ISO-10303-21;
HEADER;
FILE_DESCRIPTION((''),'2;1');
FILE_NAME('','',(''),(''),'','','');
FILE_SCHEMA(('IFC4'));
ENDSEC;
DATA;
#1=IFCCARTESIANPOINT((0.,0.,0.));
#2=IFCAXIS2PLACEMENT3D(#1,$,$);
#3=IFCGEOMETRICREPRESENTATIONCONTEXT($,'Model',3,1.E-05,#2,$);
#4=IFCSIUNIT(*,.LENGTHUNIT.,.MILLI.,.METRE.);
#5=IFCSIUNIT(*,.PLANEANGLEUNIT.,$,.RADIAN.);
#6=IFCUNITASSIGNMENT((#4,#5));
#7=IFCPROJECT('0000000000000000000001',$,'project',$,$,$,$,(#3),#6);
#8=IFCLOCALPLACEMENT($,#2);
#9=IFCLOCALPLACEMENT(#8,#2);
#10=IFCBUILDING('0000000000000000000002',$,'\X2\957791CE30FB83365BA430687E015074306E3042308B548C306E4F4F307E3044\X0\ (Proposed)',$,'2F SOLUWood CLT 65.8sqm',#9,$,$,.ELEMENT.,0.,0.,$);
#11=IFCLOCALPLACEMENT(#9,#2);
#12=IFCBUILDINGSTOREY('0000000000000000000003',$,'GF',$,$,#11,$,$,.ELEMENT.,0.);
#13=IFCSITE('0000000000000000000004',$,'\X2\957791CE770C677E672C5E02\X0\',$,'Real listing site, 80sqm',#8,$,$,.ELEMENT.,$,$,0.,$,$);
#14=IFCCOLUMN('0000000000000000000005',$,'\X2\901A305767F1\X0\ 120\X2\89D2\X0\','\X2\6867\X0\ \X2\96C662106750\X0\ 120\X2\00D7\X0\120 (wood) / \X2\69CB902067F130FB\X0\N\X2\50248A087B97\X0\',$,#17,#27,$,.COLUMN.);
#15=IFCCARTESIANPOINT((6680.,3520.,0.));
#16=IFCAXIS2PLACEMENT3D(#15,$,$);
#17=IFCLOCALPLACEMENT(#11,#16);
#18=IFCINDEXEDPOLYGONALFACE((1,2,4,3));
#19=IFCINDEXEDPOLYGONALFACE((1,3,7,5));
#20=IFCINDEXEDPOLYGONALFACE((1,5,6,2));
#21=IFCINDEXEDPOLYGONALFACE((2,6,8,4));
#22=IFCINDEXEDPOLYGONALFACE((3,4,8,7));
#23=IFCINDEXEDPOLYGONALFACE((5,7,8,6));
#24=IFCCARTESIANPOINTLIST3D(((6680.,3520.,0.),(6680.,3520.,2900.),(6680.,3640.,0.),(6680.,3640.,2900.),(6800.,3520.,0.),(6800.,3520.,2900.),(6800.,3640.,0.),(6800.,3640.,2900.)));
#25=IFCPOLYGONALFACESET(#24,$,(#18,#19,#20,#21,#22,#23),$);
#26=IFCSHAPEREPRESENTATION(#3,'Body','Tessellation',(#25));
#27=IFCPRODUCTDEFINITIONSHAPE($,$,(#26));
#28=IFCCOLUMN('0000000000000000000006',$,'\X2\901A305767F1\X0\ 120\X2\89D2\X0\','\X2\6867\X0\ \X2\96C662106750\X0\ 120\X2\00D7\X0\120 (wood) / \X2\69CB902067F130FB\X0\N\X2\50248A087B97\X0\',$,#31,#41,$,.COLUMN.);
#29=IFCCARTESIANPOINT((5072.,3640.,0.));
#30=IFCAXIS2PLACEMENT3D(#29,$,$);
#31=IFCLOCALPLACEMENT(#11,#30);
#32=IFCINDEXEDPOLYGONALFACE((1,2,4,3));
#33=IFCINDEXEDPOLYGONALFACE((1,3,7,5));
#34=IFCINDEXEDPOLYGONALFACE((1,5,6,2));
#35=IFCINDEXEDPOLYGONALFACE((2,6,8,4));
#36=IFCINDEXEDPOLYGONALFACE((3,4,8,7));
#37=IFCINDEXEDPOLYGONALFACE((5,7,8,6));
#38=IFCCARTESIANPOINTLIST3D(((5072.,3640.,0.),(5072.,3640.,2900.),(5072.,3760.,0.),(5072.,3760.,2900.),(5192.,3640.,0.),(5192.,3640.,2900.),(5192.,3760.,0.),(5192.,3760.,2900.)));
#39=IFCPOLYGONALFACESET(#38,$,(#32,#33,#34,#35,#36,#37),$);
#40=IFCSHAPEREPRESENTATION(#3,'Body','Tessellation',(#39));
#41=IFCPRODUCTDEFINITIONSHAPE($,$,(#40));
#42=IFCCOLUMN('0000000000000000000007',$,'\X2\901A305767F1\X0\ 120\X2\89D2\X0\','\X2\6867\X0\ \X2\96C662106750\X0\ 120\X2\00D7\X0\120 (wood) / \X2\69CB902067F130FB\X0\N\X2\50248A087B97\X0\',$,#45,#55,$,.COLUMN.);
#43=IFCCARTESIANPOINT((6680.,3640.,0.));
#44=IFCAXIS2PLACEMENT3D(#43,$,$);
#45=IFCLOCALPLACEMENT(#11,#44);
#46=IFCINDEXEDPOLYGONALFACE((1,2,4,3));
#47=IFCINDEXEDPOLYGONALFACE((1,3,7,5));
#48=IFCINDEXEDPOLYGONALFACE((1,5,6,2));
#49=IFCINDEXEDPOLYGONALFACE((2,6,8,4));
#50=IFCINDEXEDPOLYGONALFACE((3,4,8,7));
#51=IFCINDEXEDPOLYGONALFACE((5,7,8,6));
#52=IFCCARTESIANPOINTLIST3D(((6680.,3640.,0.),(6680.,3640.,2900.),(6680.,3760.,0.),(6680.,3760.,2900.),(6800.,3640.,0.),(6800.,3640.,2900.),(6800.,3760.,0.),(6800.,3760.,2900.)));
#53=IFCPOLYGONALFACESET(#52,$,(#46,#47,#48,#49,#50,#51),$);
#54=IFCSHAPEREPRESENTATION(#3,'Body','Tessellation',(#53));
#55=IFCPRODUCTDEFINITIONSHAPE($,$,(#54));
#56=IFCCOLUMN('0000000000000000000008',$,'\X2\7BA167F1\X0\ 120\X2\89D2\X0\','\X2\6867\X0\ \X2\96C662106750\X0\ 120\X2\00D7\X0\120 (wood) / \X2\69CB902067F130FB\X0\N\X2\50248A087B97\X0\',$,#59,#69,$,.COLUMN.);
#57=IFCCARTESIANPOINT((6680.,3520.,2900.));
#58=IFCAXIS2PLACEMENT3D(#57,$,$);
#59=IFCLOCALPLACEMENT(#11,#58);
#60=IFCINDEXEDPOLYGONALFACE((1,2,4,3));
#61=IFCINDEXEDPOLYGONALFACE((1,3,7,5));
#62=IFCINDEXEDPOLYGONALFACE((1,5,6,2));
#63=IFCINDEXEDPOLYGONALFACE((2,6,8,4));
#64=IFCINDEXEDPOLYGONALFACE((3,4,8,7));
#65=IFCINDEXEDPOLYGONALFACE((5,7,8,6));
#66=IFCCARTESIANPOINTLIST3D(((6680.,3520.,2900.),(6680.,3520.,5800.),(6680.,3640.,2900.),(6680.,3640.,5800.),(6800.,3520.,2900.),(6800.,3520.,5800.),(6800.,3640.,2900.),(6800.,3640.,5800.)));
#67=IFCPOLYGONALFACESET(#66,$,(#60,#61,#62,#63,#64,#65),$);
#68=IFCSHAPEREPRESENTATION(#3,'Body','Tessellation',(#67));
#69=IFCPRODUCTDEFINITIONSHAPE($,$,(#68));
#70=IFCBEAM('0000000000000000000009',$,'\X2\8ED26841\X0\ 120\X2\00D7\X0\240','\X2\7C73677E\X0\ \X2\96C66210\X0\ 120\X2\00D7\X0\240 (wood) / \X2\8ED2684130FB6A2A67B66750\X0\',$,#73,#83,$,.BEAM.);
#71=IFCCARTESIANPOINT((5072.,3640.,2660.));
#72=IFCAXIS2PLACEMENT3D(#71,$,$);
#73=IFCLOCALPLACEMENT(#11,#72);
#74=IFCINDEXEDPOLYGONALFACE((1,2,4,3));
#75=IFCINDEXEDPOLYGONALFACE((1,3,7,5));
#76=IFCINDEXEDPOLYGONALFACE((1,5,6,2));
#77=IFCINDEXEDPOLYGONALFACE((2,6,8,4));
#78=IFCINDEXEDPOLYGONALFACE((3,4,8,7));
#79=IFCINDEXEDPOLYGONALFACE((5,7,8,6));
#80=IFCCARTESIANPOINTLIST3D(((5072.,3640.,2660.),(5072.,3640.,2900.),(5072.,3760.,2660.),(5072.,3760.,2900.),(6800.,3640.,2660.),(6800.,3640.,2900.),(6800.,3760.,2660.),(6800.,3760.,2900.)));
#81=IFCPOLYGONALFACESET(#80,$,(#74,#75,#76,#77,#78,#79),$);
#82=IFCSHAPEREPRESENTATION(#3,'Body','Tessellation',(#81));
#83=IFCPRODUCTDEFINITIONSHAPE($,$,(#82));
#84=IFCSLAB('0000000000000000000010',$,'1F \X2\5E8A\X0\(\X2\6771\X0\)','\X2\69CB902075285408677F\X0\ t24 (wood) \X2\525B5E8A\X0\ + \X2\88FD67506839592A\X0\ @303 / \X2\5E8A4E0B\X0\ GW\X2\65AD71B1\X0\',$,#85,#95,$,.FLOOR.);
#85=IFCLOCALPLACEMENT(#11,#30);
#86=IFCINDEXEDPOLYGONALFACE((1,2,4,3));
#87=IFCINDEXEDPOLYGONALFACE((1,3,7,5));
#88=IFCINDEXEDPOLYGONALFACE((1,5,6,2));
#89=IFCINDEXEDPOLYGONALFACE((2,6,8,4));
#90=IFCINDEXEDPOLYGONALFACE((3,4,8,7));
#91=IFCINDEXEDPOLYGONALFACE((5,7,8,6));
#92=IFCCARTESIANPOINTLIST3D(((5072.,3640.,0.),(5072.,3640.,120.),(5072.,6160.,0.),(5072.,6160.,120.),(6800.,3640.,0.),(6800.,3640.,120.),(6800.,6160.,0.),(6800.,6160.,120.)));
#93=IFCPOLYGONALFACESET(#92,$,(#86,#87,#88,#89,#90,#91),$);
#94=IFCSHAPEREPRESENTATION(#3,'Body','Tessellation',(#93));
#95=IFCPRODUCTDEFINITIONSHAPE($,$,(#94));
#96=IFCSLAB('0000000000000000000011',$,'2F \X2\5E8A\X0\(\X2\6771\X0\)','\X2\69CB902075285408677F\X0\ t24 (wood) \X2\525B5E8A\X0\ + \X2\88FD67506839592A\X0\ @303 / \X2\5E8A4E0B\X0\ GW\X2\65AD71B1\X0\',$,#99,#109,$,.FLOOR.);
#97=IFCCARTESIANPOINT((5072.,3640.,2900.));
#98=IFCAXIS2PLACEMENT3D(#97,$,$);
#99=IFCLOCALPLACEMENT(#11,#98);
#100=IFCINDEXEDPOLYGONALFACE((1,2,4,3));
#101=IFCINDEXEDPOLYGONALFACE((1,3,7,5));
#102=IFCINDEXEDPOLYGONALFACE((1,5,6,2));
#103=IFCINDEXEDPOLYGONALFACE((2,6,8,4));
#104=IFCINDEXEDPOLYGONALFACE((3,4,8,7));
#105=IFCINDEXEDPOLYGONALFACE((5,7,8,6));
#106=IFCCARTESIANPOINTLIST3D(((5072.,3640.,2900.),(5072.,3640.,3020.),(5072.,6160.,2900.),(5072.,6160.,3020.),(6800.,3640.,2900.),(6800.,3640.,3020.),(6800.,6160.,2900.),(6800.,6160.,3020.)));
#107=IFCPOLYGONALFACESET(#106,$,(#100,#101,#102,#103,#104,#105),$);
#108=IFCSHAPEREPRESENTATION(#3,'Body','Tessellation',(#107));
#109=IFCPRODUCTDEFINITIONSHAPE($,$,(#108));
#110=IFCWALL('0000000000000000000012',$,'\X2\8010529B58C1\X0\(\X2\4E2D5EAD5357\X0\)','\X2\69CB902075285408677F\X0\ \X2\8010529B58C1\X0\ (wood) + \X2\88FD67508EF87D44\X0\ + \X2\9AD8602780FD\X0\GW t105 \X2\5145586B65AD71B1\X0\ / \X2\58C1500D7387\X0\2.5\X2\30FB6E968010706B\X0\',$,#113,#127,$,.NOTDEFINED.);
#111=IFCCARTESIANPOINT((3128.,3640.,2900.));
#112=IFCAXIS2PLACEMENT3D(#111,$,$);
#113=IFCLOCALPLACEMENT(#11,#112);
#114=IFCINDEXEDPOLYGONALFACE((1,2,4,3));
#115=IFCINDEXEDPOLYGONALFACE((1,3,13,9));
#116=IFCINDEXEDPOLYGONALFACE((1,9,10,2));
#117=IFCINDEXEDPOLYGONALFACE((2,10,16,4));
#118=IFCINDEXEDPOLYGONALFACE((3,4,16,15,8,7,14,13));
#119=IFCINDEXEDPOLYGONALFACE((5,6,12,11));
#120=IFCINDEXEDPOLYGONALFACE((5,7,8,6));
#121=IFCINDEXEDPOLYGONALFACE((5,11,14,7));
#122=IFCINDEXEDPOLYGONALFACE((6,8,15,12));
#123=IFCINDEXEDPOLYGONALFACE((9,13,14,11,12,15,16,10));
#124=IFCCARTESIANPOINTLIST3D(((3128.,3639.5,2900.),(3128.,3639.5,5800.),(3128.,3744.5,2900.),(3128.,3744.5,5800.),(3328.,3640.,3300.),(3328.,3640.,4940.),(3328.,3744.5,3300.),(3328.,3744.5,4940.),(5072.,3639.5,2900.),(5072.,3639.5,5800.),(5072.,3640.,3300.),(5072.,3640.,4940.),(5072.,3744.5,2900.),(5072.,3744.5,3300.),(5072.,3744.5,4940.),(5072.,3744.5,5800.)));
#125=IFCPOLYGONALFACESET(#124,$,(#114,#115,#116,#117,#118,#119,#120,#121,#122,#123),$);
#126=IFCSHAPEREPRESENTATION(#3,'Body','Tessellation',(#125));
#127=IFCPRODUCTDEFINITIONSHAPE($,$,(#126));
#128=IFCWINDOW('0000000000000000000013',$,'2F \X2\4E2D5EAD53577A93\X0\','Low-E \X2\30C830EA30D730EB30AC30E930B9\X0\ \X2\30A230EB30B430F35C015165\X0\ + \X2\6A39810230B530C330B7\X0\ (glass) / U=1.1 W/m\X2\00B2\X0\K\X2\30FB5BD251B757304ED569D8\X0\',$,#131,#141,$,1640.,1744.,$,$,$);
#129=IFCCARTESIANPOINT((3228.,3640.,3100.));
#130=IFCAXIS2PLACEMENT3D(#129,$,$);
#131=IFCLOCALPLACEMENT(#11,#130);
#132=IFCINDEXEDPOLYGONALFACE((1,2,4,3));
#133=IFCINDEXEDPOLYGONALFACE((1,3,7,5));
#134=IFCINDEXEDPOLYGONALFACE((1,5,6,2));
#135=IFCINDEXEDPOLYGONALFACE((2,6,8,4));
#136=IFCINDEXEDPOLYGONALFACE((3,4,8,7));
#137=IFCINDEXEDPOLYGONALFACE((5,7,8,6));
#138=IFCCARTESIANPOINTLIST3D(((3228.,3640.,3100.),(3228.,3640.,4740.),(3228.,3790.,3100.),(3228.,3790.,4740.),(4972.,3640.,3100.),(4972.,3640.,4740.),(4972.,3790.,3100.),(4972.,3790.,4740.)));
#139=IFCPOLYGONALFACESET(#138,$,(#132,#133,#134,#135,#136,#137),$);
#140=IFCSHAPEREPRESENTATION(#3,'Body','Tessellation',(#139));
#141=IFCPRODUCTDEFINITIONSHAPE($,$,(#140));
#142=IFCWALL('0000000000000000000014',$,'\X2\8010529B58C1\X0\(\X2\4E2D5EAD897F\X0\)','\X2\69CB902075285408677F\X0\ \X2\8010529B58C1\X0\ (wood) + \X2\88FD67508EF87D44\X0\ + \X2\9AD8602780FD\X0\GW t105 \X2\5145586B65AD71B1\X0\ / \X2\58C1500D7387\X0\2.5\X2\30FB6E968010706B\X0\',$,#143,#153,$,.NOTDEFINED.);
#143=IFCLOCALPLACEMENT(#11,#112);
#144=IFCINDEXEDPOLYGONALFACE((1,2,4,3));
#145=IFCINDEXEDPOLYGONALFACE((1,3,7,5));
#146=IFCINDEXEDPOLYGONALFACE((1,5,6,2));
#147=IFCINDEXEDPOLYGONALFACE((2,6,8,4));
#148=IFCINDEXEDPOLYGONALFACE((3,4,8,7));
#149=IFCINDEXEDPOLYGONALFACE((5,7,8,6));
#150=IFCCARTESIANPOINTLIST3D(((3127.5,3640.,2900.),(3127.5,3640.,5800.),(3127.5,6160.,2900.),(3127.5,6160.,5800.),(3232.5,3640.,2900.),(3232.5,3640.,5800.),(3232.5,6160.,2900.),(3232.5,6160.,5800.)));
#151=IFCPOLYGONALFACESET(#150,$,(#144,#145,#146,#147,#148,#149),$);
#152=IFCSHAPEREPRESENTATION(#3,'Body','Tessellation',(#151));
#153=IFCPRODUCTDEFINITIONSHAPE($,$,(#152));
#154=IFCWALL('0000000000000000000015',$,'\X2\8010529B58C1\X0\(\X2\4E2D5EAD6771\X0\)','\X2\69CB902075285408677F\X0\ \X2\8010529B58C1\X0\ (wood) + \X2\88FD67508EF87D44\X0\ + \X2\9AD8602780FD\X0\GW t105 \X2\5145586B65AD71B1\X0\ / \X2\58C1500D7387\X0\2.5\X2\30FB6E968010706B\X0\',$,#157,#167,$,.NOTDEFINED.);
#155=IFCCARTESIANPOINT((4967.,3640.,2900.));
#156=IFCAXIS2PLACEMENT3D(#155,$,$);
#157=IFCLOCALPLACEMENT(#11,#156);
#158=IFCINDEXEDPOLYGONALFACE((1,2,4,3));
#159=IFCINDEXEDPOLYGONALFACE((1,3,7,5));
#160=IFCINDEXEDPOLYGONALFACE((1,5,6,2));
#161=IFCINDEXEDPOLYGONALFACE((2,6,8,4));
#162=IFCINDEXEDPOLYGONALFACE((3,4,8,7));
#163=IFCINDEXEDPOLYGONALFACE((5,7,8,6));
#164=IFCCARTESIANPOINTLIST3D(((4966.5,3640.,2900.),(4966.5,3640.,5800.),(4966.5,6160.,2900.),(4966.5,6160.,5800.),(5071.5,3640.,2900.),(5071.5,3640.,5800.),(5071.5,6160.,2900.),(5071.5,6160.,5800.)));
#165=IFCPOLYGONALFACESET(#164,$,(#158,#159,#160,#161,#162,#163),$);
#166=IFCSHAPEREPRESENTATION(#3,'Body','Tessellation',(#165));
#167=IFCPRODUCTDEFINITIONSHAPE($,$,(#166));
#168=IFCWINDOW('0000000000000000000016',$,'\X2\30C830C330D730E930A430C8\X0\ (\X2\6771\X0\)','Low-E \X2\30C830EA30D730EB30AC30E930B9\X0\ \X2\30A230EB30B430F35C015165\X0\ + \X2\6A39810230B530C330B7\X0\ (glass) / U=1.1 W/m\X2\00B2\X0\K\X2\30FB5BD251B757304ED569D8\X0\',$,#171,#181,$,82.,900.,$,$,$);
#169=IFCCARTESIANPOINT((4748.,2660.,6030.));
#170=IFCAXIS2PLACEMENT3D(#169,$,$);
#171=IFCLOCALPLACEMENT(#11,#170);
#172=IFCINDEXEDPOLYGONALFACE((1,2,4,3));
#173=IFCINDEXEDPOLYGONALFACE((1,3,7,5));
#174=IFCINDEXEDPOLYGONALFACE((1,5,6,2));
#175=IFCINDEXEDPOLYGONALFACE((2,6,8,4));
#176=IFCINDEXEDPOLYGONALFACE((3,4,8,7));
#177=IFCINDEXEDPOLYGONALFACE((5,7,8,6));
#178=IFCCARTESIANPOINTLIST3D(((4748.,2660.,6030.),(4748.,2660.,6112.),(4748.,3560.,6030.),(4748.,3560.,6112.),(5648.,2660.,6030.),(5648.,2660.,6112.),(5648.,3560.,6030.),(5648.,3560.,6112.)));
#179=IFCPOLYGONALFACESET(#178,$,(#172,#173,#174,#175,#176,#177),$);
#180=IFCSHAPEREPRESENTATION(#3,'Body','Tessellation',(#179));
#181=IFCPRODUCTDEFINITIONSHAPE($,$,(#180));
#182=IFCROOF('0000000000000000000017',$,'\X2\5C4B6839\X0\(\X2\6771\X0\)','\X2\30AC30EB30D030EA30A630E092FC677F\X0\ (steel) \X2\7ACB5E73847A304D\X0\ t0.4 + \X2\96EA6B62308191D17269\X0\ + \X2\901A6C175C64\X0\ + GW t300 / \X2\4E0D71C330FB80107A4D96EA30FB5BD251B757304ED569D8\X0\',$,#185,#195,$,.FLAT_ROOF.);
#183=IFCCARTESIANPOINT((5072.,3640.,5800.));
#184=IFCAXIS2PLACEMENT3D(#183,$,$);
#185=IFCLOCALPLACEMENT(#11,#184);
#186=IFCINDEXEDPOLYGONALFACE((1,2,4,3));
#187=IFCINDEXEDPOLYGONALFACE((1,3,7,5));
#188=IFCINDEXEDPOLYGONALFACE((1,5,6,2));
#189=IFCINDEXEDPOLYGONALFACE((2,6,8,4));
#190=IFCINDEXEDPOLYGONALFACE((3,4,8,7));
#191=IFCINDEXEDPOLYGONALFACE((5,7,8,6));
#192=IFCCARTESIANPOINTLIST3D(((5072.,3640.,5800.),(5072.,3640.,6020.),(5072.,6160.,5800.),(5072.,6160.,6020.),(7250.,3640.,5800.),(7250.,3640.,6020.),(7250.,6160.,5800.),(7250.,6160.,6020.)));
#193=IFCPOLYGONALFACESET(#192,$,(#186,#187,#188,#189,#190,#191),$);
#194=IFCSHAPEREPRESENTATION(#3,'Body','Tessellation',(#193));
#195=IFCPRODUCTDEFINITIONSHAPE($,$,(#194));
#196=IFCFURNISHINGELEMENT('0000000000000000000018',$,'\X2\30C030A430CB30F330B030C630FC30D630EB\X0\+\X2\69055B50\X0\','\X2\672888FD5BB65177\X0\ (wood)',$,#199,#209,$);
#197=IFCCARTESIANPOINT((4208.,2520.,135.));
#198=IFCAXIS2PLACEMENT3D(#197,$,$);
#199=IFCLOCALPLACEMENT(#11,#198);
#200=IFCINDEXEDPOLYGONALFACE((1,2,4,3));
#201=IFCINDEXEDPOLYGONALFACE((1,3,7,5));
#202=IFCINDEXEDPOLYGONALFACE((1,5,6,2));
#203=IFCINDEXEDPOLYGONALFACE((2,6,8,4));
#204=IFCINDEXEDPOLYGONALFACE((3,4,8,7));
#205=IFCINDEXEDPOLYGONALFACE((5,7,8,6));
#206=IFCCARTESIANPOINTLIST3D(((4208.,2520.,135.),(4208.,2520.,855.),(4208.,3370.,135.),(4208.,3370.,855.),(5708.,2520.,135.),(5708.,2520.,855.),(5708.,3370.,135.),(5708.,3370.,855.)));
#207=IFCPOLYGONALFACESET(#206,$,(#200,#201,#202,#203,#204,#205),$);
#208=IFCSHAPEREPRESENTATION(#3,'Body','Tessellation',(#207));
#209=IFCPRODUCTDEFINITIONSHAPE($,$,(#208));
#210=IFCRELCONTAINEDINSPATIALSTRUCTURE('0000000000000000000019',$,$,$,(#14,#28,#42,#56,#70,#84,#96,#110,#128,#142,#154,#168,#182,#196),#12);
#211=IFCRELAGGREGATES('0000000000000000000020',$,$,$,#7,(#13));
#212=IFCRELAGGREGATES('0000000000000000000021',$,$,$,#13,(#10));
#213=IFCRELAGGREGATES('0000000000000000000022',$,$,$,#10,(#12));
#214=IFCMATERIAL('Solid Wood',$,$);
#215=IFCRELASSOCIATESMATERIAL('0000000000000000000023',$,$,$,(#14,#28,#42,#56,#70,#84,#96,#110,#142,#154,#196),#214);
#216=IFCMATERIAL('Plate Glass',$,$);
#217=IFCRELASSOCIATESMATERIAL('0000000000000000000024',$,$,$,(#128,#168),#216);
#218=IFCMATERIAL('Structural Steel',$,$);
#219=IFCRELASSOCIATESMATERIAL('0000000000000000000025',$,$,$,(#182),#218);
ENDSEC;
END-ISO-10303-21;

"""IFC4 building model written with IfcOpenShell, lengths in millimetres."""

from ifc_helpers import new_model, si_unit, frame, frame_2d, origin, place, context, project, spatial, rectangle, extrude, material, element, fill, save


model = new_model("IFC4")

# Units and contexts
model_context = context("Model", 3, precision=1e-05, world=origin())
ifc_project = project(units=[si_unit("LENGTHUNIT", "METRE", prefix="MILLI"), si_unit("PLANEANGLEUNIT", "RADIAN")], contexts=[model_context])

# Site, building, storey
site_placement = place(None, origin())
site = spatial("IfcSite", under=ifc_project, at=site_placement, Name="長野県松本市", ObjectType="Real listing site, 80sqm", CompositionType="ELEMENT", RefElevation=0.0)
building_placement = place(site_placement, origin())
building = spatial("IfcBuilding", under=site, at=building_placement, Name="長野・茶室と縁側のある和の住まい (Proposed)", ObjectType="2F SOLUWood CLT 65.8sqm", CompositionType="ELEMENT", ElevationOfRefHeight=0.0, ElevationOfTerrain=0.0)
storey_placement = place(building_placement, origin())
storey = spatial("IfcBuildingStorey", under=building, at=storey_placement, Name="GF", CompositionType="ELEMENT", Elevation=0.0)

# Columns
ifc_material_1 = material(Name="Solid Wood")
column_1_placement = place(storey_placement, frame((6680.0, 3520.0, 0.0)))
element("IfcColumn", 1, at=column_1_placement, inside=storey, material=ifc_material_1, Name="通し柱 120角", Description="桧 集成材 120×120 (wood) / 構造柱・N値計算", PredefinedType="COLUMN", context=model_context, shape_type="SweptSolid", body=[
    extrude(rectangle(XDim=120.0, YDim=120.0, at=frame_2d((60.0, 60.0))), frame((6680.0, 3520.0, 0.0)), (0.0, 0.0, 1.0), 2900.0),
])
column_2_placement = place(storey_placement, frame((5072.0, 3640.0, 0.0)))
element("IfcColumn", 2, at=column_2_placement, inside=storey, material=ifc_material_1, Name="通し柱 120角", Description="桧 集成材 120×120 (wood) / 構造柱・N値計算", PredefinedType="COLUMN", context=model_context, shape_type="SweptSolid", body=[
    extrude(rectangle(XDim=120.0, YDim=120.0, at=frame_2d((60.0, 60.0))), frame((5072.0, 3640.0, 0.0)), (0.0, 0.0, 1.0), 2900.0),
])
column_3_placement = place(storey_placement, frame((6680.0, 3640.0, 0.0)))
element("IfcColumn", 3, at=column_3_placement, inside=storey, material=ifc_material_1, Name="通し柱 120角", Description="桧 集成材 120×120 (wood) / 構造柱・N値計算", PredefinedType="COLUMN", context=model_context, shape_type="SweptSolid", body=[
    extrude(rectangle(XDim=120.0, YDim=120.0, at=frame_2d((60.0, 60.0))), frame((6680.0, 3640.0, 0.0)), (0.0, 0.0, 1.0), 2900.0),
])
column_4_placement = place(storey_placement, frame((6680.0, 3520.0, 2900.0)))
element("IfcColumn", 4, at=column_4_placement, inside=storey, material=ifc_material_1, Name="管柱 120角", Description="桧 集成材 120×120 (wood) / 構造柱・N値計算", PredefinedType="COLUMN", context=model_context, shape_type="SweptSolid", body=[
    extrude(rectangle(XDim=120.0, YDim=120.0, at=frame_2d((60.0, 60.0))), frame((6680.0, 3520.0, 2900.0)), (0.0, 0.0, 1.0), 2900.0),
])

# Beam
beam_1_placement = place(storey_placement, frame((5072.0, 3640.0, 2660.0)))
element("IfcBeam", 5, at=beam_1_placement, inside=storey, material=ifc_material_1, Name="軒桁 120×240", Description="米松 集成 120×240 (wood) / 軒桁・横架材", PredefinedType="BEAM", context=model_context, shape_type="SweptSolid", body=[
    extrude(rectangle(XDim=1728.0, YDim=120.0, at=frame_2d((864.0, 60.0))), frame((5072.0, 3640.0, 2660.0)), (0.0, 0.0, 1.0), 240.0),
])

# Slabs
slab_1_placement = place(storey_placement, frame((5072.0, 3640.0, 0.0)))
element("IfcSlab", 6, at=slab_1_placement, inside=storey, material=ifc_material_1, Name="1F 床(東)", Description="構造用合板 t24 (wood) 剛床 + 製材根太 @303 / 床下 GW断熱", PredefinedType="FLOOR", context=model_context, shape_type="SweptSolid", body=[
    extrude(rectangle(XDim=1728.0, YDim=2520.0, at=frame_2d((864.0, 1260.0))), frame((5072.0, 3640.0, 0.0)), (0.0, 0.0, 1.0), 120.0),
])
slab_2_placement = place(storey_placement, frame((5072.0, 3640.0, 2900.0)))
element("IfcSlab", 7, at=slab_2_placement, inside=storey, material=ifc_material_1, Name="2F 床(東)", Description="構造用合板 t24 (wood) 剛床 + 製材根太 @303 / 床下 GW断熱", PredefinedType="FLOOR", context=model_context, shape_type="SweptSolid", body=[
    extrude(rectangle(XDim=1728.0, YDim=2520.0, at=frame_2d((864.0, 1260.0))), frame((5072.0, 3640.0, 2900.0)), (0.0, 0.0, 1.0), 120.0),
])

# Wall, opening, window
wall_1_placement = place(storey_placement, frame((3128.0, 3640.0, 2900.0)))
wall_1 = element("IfcWall", 8, at=wall_1_placement, inside=storey, material=ifc_material_1, Name="耐力壁(中庭南)", Description="構造用合板 耐力壁 (wood) + 製材軸組 + 高性能GW t105 充填断熱 / 壁倍率2.5・準耐火", PredefinedType="NOTDEFINED", context=model_context, shape_type="SweptSolid", body=[
    extrude(rectangle(XDim=1944.0, YDim=105.0, at=frame_2d((972.0, 52.0))), frame((3128.0, 3640.0, 2900.0)), (0.0, 0.0, 1.0), 2900.0),
])
opening_placement = place(storey_placement, frame((3228.0, 3640.0, 3100.0)))
opening = element("IfcOpeningElement", 9, at=opening_placement, cuts=wall_1, PredefinedType="NOTDEFINED", context=model_context, shape_type="SweptSolid", body=[
    extrude(rectangle(XDim=1744.0, YDim=150.0, at=frame_2d((872.0, 75.0))), frame((3228.0, 3640.0, 3100.0)), (0.0, 0.0, 1.0), 1640.0),
])
ifc_material_2 = material(Name="Plate Glass")
window_1_placement = place(storey_placement, frame((3228.0, 3640.0, 3100.0)))
window_1 = element("IfcWindow", 10, at=window_1_placement, inside=storey, material=ifc_material_2, Name="2F 中庭南窓", Description="Low-E トリプルガラス アルゴン封入 + 樹脂サッシ (glass) / U=1.1 W/m²K・寒冷地仕様", OverallHeight=1640.0, OverallWidth=1744.0, context=model_context, shape_type="SweptSolid", body=[
    extrude(rectangle(XDim=1744.0, YDim=150.0, at=frame_2d((872.0, 75.0))), frame((3228.0, 3640.0, 3100.0)), (0.0, 0.0, 1.0), 1640.0),
])
fill(opening, window_1)

# Walls
wall_2_placement = place(storey_placement, frame((3128.0, 3640.0, 2900.0)))
element("IfcWall", 11, at=wall_2_placement, inside=storey, material=ifc_material_1, Name="耐力壁(中庭西)", Description="構造用合板 耐力壁 (wood) + 製材軸組 + 高性能GW t105 充填断熱 / 壁倍率2.5・準耐火", PredefinedType="NOTDEFINED", context=model_context, shape_type="SweptSolid", body=[
    extrude(rectangle(XDim=105.0, YDim=2520.0, at=frame_2d((52.0, 1260.0))), frame((3128.0, 3640.0, 2900.0)), (0.0, 0.0, 1.0), 2900.0),
])
wall_3_placement = place(storey_placement, frame((4967.0, 3640.0, 2900.0)))
element("IfcWall", 12, at=wall_3_placement, inside=storey, material=ifc_material_1, Name="耐力壁(中庭東)", Description="構造用合板 耐力壁 (wood) + 製材軸組 + 高性能GW t105 充填断熱 / 壁倍率2.5・準耐火", PredefinedType="NOTDEFINED", context=model_context, shape_type="SweptSolid", body=[
    extrude(rectangle(XDim=105.0, YDim=2520.0, at=frame_2d((52.0, 1260.0))), frame((4967.0, 3640.0, 2900.0)), (0.0, 0.0, 1.0), 2900.0),
])

# Window
window_2_placement = place(storey_placement, frame((4748.0, 2660.0, 6030.0)))
element("IfcWindow", 13, at=window_2_placement, inside=storey, material=ifc_material_2, Name="トップライト (東)", Description="Low-E トリプルガラス アルゴン封入 + 樹脂サッシ (glass) / U=1.1 W/m²K・寒冷地仕様", OverallHeight=82.0, OverallWidth=900.0, context=model_context, shape_type="SweptSolid", body=[
    extrude(rectangle(XDim=900.0, YDim=900.0, at=frame_2d((450.0, 450.0))), frame((4748.0, 2660.0, 6030.0)), (0.0, 0.0, 1.0), 82.0),
])

# Roof
ifc_material_3 = material(Name="Structural Steel")
for number, where, name in (
    (14, (5072.0, 3640.0, 5800.0), "屋根(東)"),
):
    element("IfcRoof", number, at=place(storey_placement, frame(where)), inside=storey, material=ifc_material_3, Name=name, Description="ガルバリウム鋼板 (steel) 立平葺き t0.4 + 雪止め金物 + 通気層 + GW t300 / 不燃・耐積雪・寒冷地仕様", PredefinedType="FLAT_ROOF", context=model_context, shape_type="SweptSolid", body=[
        extrude(rectangle(XDim=2178.0, YDim=2520.0, at=frame_2d((1089.0, 1260.0))), frame((5072.0, 3640.0, 5800.0)), (0.0, 0.0, 1.0), 220.0),
    ])

# Furnishing element
furnishing_1_placement = place(storey_placement, frame((4208.0, 2520.0, 135.0)))
element("IfcFurnishingElement", 15, at=furnishing_1_placement, inside=storey, material=ifc_material_1, Name="ダイニングテーブル+椅子", Description="木製家具 (wood)", context=model_context, shape_type="SweptSolid", body=[
    extrude(rectangle(XDim=1500.0, YDim=850.0, at=frame_2d((750.0, 425.0))), frame((4208.0, 2520.0, 135.0)), (0.0, 0.0, 1.0), 720.0),
])

save(model, "model.ifc")
